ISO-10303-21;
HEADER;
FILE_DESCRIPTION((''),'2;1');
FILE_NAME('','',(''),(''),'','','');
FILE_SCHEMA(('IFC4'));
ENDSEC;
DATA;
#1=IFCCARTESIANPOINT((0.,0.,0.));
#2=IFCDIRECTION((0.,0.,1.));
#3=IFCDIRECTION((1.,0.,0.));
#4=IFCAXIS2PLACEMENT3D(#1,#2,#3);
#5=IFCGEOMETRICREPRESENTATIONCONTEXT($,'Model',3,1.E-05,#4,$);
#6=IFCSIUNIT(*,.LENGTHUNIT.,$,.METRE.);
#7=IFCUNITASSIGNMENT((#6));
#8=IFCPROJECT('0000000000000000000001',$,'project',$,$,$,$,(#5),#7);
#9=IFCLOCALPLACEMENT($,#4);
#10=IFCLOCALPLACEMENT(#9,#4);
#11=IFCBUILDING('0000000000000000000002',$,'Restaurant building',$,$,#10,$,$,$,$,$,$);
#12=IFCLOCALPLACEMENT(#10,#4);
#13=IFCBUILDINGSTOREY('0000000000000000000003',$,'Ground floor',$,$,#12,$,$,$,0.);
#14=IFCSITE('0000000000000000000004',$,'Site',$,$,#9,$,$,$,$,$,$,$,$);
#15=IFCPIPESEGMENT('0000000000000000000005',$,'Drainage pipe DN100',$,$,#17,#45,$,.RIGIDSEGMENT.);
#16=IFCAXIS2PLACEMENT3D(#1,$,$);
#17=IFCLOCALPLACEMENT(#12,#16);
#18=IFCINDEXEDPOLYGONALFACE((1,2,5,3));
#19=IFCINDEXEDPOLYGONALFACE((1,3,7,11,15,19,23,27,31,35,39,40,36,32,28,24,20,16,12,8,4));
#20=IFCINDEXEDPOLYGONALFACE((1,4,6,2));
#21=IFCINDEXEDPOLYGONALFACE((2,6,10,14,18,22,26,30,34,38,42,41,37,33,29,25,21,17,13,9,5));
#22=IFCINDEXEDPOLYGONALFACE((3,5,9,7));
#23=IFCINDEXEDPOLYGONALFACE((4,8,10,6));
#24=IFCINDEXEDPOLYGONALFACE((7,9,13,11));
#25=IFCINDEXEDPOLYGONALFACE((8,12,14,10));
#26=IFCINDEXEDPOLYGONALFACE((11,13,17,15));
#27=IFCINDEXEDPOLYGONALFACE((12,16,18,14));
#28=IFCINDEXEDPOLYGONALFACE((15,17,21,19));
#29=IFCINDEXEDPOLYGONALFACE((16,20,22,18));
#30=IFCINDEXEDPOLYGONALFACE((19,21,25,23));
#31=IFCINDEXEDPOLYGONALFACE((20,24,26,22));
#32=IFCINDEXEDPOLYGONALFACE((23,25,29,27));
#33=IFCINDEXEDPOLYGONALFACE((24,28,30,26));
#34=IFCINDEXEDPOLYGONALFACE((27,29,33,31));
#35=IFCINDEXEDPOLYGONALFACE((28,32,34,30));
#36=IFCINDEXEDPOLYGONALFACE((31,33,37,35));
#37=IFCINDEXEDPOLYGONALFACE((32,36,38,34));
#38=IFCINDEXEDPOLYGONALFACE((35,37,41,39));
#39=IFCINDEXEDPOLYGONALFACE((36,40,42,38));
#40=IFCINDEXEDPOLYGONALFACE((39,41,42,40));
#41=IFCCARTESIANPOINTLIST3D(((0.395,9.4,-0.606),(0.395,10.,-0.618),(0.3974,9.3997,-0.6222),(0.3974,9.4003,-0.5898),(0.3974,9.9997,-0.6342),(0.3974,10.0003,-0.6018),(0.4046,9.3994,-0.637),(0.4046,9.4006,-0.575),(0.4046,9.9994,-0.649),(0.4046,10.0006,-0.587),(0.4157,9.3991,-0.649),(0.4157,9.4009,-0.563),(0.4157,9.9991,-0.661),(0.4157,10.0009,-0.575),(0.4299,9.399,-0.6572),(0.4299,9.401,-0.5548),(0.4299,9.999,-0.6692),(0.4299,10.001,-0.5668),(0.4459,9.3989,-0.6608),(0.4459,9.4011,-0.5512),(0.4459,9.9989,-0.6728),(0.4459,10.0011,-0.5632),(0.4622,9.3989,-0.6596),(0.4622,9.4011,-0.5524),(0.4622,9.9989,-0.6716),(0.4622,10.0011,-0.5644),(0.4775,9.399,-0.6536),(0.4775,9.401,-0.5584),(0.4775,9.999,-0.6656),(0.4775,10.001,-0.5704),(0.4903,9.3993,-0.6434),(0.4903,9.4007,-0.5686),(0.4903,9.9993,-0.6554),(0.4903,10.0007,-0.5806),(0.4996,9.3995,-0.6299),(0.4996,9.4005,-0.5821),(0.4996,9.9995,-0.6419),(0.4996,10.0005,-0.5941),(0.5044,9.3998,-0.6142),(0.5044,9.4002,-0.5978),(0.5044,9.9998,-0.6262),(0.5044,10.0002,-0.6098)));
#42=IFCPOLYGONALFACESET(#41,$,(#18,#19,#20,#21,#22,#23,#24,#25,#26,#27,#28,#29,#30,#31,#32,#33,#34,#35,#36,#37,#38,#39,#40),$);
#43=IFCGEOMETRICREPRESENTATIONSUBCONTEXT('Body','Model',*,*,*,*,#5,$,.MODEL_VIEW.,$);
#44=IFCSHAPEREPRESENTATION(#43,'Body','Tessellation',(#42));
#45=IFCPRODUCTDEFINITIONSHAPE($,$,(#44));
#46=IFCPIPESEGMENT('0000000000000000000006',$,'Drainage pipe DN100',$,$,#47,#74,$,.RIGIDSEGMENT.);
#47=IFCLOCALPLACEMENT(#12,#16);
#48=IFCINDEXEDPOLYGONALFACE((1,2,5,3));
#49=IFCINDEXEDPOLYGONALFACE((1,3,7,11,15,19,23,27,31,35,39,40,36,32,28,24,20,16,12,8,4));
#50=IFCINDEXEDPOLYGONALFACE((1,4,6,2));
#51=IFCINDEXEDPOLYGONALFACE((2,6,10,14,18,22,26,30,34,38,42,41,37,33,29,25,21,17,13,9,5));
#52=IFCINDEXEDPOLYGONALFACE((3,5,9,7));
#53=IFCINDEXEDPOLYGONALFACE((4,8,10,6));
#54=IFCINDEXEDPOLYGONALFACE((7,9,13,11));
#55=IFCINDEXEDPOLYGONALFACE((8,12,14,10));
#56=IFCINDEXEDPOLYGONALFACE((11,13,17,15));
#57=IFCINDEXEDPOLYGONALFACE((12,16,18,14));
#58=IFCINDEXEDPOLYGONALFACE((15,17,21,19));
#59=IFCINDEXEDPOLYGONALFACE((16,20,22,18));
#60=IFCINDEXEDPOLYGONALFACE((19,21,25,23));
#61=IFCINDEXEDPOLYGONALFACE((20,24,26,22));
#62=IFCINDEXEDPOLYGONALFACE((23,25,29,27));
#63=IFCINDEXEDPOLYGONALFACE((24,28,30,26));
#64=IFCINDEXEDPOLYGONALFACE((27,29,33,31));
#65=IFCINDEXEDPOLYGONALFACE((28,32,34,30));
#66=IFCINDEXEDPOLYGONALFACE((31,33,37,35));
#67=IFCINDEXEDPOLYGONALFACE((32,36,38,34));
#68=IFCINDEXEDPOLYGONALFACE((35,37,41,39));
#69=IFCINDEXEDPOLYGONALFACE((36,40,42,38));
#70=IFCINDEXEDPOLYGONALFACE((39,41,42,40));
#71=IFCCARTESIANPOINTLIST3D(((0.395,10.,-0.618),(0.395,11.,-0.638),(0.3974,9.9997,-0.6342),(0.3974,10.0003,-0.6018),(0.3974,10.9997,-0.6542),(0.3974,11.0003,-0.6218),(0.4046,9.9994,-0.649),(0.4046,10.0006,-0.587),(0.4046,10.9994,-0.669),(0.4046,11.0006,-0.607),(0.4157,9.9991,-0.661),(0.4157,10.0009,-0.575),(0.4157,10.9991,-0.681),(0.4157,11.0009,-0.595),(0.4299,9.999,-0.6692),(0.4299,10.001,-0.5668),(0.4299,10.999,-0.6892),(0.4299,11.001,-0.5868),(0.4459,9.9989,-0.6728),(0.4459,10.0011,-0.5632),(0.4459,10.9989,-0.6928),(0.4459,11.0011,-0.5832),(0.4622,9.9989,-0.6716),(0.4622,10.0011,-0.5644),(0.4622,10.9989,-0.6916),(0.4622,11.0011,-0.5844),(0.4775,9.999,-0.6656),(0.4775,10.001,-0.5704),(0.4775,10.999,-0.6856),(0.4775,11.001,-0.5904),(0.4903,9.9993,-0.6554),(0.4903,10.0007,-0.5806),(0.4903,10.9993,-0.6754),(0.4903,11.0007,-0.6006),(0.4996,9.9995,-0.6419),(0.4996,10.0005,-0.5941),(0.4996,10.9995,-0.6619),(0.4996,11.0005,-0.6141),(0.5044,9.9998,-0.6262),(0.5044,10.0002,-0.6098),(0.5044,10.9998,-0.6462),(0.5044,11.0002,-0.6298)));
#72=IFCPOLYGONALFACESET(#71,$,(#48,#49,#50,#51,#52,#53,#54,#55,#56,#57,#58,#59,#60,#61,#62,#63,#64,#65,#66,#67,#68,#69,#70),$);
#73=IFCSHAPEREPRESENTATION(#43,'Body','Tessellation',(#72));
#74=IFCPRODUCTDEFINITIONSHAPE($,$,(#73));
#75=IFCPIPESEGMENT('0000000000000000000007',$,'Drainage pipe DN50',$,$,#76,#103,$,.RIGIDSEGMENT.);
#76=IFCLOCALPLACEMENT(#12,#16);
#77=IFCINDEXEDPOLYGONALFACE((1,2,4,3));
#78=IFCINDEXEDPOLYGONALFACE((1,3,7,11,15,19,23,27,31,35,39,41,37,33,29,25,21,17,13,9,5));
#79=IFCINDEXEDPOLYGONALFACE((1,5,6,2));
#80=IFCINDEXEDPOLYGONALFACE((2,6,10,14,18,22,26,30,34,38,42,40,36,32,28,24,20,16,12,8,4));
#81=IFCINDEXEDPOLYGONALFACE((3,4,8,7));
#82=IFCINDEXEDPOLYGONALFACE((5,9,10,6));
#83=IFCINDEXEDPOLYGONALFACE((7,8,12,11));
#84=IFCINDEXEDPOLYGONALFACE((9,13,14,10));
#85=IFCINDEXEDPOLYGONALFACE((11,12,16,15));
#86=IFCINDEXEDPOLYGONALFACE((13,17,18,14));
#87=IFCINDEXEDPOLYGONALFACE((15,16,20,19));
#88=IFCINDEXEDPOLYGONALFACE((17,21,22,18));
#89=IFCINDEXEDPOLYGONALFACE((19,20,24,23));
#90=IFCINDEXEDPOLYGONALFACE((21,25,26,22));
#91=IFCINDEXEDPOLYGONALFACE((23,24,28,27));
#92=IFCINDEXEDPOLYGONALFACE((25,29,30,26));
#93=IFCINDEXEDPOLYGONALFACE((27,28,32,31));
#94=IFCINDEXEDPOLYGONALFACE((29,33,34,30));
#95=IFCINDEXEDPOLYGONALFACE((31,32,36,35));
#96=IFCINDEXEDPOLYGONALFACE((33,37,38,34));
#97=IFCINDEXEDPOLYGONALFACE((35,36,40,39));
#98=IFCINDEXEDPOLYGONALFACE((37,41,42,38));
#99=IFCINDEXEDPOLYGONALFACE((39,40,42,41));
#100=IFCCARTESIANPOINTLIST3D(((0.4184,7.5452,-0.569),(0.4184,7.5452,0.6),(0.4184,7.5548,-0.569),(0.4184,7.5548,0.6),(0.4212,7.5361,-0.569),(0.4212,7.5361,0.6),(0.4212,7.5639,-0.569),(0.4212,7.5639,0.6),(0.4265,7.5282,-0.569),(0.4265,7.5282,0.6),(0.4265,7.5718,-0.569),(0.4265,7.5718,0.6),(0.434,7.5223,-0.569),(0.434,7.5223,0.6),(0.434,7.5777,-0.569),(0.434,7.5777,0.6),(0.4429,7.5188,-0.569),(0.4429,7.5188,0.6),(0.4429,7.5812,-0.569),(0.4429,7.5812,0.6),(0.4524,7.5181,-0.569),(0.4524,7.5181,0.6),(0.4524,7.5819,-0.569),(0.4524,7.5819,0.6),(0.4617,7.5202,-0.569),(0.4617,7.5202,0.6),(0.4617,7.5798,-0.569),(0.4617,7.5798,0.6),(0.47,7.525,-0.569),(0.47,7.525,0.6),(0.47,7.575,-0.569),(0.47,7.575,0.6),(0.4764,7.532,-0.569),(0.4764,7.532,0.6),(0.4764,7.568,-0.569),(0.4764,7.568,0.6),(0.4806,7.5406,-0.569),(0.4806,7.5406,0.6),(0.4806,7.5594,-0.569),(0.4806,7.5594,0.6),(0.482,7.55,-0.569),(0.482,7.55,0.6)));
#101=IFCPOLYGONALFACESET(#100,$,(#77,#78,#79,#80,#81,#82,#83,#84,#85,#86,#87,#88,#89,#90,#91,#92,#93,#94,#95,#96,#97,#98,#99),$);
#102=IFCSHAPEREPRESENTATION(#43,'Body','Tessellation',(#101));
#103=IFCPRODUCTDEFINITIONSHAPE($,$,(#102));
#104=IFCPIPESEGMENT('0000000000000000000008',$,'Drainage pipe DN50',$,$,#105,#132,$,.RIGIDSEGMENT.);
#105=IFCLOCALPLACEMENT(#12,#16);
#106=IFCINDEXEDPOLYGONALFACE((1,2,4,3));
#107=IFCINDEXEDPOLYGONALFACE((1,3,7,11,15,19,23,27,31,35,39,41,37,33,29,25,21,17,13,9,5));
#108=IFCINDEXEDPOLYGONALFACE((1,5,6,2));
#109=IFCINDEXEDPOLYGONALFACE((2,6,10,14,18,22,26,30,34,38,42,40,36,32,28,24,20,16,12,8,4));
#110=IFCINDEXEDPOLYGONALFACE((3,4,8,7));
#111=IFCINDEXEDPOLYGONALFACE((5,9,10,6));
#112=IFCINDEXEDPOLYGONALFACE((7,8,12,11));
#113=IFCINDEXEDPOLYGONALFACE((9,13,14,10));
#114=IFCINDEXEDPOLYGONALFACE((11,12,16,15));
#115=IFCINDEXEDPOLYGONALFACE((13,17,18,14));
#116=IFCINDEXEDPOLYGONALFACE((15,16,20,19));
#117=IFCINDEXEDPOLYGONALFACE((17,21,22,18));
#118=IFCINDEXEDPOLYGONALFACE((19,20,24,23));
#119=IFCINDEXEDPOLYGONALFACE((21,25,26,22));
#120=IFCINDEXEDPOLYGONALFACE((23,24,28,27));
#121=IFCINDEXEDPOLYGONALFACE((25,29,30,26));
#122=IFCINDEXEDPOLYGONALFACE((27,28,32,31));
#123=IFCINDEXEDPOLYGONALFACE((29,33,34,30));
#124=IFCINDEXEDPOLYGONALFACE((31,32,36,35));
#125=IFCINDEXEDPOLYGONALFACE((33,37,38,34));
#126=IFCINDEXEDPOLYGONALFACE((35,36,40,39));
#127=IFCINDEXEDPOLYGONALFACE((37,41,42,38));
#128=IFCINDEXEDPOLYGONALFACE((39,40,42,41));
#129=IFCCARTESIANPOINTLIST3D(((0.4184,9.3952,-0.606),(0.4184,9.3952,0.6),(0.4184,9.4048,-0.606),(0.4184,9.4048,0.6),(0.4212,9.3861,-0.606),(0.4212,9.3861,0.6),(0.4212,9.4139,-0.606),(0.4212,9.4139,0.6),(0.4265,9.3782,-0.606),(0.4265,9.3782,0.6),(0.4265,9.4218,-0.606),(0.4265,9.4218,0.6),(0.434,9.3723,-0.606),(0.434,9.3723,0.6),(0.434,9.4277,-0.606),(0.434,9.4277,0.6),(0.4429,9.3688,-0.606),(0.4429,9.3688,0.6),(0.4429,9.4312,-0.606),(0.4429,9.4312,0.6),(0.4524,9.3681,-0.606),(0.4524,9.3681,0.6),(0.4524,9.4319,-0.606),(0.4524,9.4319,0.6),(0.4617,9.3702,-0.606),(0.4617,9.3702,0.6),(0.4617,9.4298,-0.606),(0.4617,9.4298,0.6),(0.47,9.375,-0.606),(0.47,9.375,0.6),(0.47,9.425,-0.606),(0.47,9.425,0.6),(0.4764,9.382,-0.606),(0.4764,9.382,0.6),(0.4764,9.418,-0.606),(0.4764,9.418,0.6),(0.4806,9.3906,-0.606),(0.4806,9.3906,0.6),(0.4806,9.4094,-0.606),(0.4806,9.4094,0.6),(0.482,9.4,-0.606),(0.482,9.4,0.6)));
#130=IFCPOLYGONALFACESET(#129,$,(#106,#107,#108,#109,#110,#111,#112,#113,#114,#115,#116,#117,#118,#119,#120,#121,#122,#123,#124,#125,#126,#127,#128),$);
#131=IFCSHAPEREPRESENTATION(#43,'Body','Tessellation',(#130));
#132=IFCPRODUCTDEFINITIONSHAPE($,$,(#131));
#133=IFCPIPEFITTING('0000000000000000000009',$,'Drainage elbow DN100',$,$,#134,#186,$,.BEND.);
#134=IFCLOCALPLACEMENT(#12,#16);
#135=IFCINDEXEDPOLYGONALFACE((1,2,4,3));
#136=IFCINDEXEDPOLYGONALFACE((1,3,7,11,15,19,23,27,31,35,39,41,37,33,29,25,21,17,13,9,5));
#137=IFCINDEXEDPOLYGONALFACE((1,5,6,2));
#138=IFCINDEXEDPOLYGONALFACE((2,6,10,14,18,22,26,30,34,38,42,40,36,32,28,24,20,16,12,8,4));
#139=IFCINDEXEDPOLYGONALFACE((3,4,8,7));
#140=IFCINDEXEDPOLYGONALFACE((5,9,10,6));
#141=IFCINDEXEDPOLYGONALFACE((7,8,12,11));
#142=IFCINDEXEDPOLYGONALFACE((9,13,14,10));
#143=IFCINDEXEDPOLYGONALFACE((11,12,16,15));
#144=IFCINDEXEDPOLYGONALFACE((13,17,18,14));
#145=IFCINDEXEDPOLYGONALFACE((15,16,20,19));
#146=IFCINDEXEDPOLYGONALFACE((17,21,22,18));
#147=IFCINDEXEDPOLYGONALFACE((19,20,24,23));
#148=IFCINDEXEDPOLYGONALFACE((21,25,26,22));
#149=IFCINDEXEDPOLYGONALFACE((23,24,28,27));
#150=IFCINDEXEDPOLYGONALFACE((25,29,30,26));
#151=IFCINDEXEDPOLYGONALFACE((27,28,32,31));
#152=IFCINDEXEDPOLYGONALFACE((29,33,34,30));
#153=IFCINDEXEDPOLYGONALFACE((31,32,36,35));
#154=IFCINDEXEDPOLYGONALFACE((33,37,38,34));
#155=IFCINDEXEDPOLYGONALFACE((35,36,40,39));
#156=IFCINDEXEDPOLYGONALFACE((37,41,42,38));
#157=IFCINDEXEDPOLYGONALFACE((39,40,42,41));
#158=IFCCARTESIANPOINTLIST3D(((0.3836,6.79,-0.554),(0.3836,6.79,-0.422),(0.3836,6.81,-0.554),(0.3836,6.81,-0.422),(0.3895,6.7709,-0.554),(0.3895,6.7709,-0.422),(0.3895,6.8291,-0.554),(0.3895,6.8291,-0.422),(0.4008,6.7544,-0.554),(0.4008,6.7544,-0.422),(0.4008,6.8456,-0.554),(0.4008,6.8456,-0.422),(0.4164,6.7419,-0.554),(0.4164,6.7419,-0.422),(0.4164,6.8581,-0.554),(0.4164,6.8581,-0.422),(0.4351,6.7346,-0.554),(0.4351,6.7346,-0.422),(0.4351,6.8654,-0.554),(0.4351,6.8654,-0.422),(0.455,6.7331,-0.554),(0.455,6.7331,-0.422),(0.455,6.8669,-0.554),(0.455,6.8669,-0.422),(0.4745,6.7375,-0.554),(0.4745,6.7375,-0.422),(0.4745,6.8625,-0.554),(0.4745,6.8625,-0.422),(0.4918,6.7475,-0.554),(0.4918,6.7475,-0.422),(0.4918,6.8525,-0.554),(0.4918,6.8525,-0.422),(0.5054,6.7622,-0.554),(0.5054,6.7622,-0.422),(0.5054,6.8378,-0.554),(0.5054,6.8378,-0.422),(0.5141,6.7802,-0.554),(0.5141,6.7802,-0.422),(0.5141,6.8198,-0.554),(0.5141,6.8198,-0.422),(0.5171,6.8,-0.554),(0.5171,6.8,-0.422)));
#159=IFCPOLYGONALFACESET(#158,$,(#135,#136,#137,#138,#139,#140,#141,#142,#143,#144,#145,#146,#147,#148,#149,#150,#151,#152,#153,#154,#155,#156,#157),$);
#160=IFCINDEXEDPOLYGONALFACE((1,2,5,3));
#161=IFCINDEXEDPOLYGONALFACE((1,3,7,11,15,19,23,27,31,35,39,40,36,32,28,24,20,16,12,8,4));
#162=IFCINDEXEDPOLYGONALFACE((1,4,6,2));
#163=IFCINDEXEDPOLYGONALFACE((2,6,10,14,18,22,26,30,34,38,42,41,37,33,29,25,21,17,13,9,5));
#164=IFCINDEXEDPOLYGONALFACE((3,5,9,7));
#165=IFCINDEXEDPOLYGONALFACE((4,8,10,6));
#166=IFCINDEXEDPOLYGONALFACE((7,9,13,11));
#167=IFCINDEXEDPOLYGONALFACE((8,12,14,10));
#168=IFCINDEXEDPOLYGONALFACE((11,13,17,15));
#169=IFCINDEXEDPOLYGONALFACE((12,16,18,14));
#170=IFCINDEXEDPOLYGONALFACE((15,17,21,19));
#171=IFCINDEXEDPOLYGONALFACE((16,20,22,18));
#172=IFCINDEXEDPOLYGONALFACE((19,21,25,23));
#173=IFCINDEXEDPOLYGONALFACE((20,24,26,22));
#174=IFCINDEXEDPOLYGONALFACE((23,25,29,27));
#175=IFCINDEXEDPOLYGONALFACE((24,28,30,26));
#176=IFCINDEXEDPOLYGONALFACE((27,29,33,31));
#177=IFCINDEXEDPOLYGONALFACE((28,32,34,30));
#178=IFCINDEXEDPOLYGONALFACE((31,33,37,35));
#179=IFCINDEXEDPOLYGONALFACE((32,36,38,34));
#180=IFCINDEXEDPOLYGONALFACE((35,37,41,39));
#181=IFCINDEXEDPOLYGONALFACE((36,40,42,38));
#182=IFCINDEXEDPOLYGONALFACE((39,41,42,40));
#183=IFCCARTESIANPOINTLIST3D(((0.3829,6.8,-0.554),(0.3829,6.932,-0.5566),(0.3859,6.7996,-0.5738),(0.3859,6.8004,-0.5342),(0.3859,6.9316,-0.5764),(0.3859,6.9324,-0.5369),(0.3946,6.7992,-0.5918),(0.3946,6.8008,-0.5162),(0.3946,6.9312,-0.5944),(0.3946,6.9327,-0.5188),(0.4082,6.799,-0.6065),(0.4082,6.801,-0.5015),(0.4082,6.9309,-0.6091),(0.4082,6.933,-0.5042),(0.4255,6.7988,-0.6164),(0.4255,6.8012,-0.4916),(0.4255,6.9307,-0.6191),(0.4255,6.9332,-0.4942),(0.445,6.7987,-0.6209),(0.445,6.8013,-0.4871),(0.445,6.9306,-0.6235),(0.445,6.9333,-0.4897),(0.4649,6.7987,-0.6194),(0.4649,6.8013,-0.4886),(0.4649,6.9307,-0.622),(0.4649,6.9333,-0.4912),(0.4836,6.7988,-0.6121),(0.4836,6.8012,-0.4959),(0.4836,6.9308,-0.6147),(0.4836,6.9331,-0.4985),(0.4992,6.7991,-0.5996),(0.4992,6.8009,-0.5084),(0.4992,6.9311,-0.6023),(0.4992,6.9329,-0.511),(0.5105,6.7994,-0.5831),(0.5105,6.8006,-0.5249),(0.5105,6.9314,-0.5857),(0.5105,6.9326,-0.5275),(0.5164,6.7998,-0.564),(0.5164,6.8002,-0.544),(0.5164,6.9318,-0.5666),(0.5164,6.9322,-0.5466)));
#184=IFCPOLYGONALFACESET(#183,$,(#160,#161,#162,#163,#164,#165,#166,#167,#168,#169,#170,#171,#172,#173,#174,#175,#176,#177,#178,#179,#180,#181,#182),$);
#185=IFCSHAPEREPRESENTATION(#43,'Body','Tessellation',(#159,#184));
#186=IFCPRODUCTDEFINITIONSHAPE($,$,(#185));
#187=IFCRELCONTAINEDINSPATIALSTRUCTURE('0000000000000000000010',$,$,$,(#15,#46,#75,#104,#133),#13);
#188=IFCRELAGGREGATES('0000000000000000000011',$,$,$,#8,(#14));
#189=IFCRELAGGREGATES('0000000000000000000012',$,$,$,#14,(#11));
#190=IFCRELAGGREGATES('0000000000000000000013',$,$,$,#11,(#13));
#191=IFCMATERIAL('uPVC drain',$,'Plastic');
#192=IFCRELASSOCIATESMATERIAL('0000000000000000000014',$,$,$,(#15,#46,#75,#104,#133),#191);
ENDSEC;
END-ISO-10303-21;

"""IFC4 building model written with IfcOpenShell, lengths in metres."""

from ifc_helpers import new_model, si_unit, frame, origin, origin_with_axes, origin_2d, place, context, subcontext, project, spatial, circle, extrude, material, element, save


model = new_model("IFC4")

# Units and contexts
model_context = context("Model", 3, precision=1e-05, world=origin_with_axes())
body_context = subcontext(model_context, "Body", "Model", "MODEL_VIEW")
ifc_project = project(units=[si_unit("LENGTHUNIT", "METRE")], contexts=[model_context])

# Site, building, storey
site_placement = place(None, origin_with_axes())
site = spatial("IfcSite", under=ifc_project, at=site_placement, Name="Site")
building_placement = place(site_placement, origin_with_axes())
building = spatial("IfcBuilding", under=site, at=building_placement, Name="Restaurant building")
storey_placement = place(building_placement, origin_with_axes())
storey = spatial("IfcBuildingStorey", under=building, at=storey_placement, Name="Ground floor", Elevation=0.0)

# Pipe segments
ifc_material_1 = material(Name="uPVC drain", Category="Plastic")
pipe_segment_1_placement = place(storey_placement, frame((0.45, 9.4, -0.606)))
element("IfcPipeSegment", 1, at=pipe_segment_1_placement, inside=storey, material=ifc_material_1, Name="Drainage pipe DN100", PredefinedType="RIGIDSEGMENT", context=body_context, shape_type="SweptSolid", body=[
    extrude(circle(Radius=0.055, at=origin_2d()), frame((0.0, 0.0, 0.0), z_axis=(0.0, 0.9998, -0.019996), x_axis=(-1.0, 0.0, 0.0)), (0.0, 0.0, 1.0), 0.6001),
])
pipe_segment_2_placement = place(storey_placement, frame((0.45, 10.0, -0.618)))
element("IfcPipeSegment", 2, at=pipe_segment_2_placement, inside=storey, material=ifc_material_1, Name="Drainage pipe DN100", PredefinedType="RIGIDSEGMENT", context=body_context, shape_type="SweptSolid", body=[
    extrude(circle(Radius=0.055, at=origin_2d()), frame((0.0, 0.0, 0.0), z_axis=(0.0, 0.9998, -0.019996), x_axis=(-1.0, 0.0, 0.0)), (0.0, 0.0, 1.0), 1.0002),
])
pipe_segment_3_placement = place(storey_placement, frame((0.45, 7.55, 0.6)))
element("IfcPipeSegment", 3, at=pipe_segment_3_placement, inside=storey, material=ifc_material_1, Name="Drainage pipe DN50", PredefinedType="RIGIDSEGMENT", context=body_context, shape_type="SweptSolid", body=[
    extrude(circle(Radius=0.032, at=origin_2d()), frame((0.0, 0.0, 0.0), z_axis=(0.0, 0.0, -1.0), x_axis=(1.0, 0.0, 0.0)), (0.0, 0.0, 1.0), 1.169),
])
pipe_segment_4_placement = place(storey_placement, frame((0.45, 9.4, 0.6)))
element("IfcPipeSegment", 4, at=pipe_segment_4_placement, inside=storey, material=ifc_material_1, Name="Drainage pipe DN50", PredefinedType="RIGIDSEGMENT", context=body_context, shape_type="SweptSolid", body=[
    extrude(circle(Radius=0.032, at=origin_2d()), frame((0.0, 0.0, 0.0), z_axis=(0.0, 0.0, -1.0), x_axis=(1.0, 0.0, 0.0)), (0.0, 0.0, 1.0), 1.206),
])

# Pipe fitting
pipe_fitting_1_placement = place(storey_placement, frame((0.45, 6.8, -0.554)))
element("IfcPipeFitting", 5, at=pipe_fitting_1_placement, inside=storey, material=ifc_material_1, Name="Drainage elbow DN100", PredefinedType="BEND", context=body_context, shape_type="SweptSolid", body=[
    extrude(circle(Radius=0.0671, at=origin_2d()), origin(), (0.0, 0.0, 1.0), 0.132),
    extrude(circle(Radius=0.0671, at=origin_2d()), frame((0.0, 0.0, 0.0), z_axis=(0.0, 0.9998, -0.019996), x_axis=(-1.0, 0.0, 0.0)), (0.0, 0.0, 1.0), 0.132),
])

save(model, "model.ifc")
